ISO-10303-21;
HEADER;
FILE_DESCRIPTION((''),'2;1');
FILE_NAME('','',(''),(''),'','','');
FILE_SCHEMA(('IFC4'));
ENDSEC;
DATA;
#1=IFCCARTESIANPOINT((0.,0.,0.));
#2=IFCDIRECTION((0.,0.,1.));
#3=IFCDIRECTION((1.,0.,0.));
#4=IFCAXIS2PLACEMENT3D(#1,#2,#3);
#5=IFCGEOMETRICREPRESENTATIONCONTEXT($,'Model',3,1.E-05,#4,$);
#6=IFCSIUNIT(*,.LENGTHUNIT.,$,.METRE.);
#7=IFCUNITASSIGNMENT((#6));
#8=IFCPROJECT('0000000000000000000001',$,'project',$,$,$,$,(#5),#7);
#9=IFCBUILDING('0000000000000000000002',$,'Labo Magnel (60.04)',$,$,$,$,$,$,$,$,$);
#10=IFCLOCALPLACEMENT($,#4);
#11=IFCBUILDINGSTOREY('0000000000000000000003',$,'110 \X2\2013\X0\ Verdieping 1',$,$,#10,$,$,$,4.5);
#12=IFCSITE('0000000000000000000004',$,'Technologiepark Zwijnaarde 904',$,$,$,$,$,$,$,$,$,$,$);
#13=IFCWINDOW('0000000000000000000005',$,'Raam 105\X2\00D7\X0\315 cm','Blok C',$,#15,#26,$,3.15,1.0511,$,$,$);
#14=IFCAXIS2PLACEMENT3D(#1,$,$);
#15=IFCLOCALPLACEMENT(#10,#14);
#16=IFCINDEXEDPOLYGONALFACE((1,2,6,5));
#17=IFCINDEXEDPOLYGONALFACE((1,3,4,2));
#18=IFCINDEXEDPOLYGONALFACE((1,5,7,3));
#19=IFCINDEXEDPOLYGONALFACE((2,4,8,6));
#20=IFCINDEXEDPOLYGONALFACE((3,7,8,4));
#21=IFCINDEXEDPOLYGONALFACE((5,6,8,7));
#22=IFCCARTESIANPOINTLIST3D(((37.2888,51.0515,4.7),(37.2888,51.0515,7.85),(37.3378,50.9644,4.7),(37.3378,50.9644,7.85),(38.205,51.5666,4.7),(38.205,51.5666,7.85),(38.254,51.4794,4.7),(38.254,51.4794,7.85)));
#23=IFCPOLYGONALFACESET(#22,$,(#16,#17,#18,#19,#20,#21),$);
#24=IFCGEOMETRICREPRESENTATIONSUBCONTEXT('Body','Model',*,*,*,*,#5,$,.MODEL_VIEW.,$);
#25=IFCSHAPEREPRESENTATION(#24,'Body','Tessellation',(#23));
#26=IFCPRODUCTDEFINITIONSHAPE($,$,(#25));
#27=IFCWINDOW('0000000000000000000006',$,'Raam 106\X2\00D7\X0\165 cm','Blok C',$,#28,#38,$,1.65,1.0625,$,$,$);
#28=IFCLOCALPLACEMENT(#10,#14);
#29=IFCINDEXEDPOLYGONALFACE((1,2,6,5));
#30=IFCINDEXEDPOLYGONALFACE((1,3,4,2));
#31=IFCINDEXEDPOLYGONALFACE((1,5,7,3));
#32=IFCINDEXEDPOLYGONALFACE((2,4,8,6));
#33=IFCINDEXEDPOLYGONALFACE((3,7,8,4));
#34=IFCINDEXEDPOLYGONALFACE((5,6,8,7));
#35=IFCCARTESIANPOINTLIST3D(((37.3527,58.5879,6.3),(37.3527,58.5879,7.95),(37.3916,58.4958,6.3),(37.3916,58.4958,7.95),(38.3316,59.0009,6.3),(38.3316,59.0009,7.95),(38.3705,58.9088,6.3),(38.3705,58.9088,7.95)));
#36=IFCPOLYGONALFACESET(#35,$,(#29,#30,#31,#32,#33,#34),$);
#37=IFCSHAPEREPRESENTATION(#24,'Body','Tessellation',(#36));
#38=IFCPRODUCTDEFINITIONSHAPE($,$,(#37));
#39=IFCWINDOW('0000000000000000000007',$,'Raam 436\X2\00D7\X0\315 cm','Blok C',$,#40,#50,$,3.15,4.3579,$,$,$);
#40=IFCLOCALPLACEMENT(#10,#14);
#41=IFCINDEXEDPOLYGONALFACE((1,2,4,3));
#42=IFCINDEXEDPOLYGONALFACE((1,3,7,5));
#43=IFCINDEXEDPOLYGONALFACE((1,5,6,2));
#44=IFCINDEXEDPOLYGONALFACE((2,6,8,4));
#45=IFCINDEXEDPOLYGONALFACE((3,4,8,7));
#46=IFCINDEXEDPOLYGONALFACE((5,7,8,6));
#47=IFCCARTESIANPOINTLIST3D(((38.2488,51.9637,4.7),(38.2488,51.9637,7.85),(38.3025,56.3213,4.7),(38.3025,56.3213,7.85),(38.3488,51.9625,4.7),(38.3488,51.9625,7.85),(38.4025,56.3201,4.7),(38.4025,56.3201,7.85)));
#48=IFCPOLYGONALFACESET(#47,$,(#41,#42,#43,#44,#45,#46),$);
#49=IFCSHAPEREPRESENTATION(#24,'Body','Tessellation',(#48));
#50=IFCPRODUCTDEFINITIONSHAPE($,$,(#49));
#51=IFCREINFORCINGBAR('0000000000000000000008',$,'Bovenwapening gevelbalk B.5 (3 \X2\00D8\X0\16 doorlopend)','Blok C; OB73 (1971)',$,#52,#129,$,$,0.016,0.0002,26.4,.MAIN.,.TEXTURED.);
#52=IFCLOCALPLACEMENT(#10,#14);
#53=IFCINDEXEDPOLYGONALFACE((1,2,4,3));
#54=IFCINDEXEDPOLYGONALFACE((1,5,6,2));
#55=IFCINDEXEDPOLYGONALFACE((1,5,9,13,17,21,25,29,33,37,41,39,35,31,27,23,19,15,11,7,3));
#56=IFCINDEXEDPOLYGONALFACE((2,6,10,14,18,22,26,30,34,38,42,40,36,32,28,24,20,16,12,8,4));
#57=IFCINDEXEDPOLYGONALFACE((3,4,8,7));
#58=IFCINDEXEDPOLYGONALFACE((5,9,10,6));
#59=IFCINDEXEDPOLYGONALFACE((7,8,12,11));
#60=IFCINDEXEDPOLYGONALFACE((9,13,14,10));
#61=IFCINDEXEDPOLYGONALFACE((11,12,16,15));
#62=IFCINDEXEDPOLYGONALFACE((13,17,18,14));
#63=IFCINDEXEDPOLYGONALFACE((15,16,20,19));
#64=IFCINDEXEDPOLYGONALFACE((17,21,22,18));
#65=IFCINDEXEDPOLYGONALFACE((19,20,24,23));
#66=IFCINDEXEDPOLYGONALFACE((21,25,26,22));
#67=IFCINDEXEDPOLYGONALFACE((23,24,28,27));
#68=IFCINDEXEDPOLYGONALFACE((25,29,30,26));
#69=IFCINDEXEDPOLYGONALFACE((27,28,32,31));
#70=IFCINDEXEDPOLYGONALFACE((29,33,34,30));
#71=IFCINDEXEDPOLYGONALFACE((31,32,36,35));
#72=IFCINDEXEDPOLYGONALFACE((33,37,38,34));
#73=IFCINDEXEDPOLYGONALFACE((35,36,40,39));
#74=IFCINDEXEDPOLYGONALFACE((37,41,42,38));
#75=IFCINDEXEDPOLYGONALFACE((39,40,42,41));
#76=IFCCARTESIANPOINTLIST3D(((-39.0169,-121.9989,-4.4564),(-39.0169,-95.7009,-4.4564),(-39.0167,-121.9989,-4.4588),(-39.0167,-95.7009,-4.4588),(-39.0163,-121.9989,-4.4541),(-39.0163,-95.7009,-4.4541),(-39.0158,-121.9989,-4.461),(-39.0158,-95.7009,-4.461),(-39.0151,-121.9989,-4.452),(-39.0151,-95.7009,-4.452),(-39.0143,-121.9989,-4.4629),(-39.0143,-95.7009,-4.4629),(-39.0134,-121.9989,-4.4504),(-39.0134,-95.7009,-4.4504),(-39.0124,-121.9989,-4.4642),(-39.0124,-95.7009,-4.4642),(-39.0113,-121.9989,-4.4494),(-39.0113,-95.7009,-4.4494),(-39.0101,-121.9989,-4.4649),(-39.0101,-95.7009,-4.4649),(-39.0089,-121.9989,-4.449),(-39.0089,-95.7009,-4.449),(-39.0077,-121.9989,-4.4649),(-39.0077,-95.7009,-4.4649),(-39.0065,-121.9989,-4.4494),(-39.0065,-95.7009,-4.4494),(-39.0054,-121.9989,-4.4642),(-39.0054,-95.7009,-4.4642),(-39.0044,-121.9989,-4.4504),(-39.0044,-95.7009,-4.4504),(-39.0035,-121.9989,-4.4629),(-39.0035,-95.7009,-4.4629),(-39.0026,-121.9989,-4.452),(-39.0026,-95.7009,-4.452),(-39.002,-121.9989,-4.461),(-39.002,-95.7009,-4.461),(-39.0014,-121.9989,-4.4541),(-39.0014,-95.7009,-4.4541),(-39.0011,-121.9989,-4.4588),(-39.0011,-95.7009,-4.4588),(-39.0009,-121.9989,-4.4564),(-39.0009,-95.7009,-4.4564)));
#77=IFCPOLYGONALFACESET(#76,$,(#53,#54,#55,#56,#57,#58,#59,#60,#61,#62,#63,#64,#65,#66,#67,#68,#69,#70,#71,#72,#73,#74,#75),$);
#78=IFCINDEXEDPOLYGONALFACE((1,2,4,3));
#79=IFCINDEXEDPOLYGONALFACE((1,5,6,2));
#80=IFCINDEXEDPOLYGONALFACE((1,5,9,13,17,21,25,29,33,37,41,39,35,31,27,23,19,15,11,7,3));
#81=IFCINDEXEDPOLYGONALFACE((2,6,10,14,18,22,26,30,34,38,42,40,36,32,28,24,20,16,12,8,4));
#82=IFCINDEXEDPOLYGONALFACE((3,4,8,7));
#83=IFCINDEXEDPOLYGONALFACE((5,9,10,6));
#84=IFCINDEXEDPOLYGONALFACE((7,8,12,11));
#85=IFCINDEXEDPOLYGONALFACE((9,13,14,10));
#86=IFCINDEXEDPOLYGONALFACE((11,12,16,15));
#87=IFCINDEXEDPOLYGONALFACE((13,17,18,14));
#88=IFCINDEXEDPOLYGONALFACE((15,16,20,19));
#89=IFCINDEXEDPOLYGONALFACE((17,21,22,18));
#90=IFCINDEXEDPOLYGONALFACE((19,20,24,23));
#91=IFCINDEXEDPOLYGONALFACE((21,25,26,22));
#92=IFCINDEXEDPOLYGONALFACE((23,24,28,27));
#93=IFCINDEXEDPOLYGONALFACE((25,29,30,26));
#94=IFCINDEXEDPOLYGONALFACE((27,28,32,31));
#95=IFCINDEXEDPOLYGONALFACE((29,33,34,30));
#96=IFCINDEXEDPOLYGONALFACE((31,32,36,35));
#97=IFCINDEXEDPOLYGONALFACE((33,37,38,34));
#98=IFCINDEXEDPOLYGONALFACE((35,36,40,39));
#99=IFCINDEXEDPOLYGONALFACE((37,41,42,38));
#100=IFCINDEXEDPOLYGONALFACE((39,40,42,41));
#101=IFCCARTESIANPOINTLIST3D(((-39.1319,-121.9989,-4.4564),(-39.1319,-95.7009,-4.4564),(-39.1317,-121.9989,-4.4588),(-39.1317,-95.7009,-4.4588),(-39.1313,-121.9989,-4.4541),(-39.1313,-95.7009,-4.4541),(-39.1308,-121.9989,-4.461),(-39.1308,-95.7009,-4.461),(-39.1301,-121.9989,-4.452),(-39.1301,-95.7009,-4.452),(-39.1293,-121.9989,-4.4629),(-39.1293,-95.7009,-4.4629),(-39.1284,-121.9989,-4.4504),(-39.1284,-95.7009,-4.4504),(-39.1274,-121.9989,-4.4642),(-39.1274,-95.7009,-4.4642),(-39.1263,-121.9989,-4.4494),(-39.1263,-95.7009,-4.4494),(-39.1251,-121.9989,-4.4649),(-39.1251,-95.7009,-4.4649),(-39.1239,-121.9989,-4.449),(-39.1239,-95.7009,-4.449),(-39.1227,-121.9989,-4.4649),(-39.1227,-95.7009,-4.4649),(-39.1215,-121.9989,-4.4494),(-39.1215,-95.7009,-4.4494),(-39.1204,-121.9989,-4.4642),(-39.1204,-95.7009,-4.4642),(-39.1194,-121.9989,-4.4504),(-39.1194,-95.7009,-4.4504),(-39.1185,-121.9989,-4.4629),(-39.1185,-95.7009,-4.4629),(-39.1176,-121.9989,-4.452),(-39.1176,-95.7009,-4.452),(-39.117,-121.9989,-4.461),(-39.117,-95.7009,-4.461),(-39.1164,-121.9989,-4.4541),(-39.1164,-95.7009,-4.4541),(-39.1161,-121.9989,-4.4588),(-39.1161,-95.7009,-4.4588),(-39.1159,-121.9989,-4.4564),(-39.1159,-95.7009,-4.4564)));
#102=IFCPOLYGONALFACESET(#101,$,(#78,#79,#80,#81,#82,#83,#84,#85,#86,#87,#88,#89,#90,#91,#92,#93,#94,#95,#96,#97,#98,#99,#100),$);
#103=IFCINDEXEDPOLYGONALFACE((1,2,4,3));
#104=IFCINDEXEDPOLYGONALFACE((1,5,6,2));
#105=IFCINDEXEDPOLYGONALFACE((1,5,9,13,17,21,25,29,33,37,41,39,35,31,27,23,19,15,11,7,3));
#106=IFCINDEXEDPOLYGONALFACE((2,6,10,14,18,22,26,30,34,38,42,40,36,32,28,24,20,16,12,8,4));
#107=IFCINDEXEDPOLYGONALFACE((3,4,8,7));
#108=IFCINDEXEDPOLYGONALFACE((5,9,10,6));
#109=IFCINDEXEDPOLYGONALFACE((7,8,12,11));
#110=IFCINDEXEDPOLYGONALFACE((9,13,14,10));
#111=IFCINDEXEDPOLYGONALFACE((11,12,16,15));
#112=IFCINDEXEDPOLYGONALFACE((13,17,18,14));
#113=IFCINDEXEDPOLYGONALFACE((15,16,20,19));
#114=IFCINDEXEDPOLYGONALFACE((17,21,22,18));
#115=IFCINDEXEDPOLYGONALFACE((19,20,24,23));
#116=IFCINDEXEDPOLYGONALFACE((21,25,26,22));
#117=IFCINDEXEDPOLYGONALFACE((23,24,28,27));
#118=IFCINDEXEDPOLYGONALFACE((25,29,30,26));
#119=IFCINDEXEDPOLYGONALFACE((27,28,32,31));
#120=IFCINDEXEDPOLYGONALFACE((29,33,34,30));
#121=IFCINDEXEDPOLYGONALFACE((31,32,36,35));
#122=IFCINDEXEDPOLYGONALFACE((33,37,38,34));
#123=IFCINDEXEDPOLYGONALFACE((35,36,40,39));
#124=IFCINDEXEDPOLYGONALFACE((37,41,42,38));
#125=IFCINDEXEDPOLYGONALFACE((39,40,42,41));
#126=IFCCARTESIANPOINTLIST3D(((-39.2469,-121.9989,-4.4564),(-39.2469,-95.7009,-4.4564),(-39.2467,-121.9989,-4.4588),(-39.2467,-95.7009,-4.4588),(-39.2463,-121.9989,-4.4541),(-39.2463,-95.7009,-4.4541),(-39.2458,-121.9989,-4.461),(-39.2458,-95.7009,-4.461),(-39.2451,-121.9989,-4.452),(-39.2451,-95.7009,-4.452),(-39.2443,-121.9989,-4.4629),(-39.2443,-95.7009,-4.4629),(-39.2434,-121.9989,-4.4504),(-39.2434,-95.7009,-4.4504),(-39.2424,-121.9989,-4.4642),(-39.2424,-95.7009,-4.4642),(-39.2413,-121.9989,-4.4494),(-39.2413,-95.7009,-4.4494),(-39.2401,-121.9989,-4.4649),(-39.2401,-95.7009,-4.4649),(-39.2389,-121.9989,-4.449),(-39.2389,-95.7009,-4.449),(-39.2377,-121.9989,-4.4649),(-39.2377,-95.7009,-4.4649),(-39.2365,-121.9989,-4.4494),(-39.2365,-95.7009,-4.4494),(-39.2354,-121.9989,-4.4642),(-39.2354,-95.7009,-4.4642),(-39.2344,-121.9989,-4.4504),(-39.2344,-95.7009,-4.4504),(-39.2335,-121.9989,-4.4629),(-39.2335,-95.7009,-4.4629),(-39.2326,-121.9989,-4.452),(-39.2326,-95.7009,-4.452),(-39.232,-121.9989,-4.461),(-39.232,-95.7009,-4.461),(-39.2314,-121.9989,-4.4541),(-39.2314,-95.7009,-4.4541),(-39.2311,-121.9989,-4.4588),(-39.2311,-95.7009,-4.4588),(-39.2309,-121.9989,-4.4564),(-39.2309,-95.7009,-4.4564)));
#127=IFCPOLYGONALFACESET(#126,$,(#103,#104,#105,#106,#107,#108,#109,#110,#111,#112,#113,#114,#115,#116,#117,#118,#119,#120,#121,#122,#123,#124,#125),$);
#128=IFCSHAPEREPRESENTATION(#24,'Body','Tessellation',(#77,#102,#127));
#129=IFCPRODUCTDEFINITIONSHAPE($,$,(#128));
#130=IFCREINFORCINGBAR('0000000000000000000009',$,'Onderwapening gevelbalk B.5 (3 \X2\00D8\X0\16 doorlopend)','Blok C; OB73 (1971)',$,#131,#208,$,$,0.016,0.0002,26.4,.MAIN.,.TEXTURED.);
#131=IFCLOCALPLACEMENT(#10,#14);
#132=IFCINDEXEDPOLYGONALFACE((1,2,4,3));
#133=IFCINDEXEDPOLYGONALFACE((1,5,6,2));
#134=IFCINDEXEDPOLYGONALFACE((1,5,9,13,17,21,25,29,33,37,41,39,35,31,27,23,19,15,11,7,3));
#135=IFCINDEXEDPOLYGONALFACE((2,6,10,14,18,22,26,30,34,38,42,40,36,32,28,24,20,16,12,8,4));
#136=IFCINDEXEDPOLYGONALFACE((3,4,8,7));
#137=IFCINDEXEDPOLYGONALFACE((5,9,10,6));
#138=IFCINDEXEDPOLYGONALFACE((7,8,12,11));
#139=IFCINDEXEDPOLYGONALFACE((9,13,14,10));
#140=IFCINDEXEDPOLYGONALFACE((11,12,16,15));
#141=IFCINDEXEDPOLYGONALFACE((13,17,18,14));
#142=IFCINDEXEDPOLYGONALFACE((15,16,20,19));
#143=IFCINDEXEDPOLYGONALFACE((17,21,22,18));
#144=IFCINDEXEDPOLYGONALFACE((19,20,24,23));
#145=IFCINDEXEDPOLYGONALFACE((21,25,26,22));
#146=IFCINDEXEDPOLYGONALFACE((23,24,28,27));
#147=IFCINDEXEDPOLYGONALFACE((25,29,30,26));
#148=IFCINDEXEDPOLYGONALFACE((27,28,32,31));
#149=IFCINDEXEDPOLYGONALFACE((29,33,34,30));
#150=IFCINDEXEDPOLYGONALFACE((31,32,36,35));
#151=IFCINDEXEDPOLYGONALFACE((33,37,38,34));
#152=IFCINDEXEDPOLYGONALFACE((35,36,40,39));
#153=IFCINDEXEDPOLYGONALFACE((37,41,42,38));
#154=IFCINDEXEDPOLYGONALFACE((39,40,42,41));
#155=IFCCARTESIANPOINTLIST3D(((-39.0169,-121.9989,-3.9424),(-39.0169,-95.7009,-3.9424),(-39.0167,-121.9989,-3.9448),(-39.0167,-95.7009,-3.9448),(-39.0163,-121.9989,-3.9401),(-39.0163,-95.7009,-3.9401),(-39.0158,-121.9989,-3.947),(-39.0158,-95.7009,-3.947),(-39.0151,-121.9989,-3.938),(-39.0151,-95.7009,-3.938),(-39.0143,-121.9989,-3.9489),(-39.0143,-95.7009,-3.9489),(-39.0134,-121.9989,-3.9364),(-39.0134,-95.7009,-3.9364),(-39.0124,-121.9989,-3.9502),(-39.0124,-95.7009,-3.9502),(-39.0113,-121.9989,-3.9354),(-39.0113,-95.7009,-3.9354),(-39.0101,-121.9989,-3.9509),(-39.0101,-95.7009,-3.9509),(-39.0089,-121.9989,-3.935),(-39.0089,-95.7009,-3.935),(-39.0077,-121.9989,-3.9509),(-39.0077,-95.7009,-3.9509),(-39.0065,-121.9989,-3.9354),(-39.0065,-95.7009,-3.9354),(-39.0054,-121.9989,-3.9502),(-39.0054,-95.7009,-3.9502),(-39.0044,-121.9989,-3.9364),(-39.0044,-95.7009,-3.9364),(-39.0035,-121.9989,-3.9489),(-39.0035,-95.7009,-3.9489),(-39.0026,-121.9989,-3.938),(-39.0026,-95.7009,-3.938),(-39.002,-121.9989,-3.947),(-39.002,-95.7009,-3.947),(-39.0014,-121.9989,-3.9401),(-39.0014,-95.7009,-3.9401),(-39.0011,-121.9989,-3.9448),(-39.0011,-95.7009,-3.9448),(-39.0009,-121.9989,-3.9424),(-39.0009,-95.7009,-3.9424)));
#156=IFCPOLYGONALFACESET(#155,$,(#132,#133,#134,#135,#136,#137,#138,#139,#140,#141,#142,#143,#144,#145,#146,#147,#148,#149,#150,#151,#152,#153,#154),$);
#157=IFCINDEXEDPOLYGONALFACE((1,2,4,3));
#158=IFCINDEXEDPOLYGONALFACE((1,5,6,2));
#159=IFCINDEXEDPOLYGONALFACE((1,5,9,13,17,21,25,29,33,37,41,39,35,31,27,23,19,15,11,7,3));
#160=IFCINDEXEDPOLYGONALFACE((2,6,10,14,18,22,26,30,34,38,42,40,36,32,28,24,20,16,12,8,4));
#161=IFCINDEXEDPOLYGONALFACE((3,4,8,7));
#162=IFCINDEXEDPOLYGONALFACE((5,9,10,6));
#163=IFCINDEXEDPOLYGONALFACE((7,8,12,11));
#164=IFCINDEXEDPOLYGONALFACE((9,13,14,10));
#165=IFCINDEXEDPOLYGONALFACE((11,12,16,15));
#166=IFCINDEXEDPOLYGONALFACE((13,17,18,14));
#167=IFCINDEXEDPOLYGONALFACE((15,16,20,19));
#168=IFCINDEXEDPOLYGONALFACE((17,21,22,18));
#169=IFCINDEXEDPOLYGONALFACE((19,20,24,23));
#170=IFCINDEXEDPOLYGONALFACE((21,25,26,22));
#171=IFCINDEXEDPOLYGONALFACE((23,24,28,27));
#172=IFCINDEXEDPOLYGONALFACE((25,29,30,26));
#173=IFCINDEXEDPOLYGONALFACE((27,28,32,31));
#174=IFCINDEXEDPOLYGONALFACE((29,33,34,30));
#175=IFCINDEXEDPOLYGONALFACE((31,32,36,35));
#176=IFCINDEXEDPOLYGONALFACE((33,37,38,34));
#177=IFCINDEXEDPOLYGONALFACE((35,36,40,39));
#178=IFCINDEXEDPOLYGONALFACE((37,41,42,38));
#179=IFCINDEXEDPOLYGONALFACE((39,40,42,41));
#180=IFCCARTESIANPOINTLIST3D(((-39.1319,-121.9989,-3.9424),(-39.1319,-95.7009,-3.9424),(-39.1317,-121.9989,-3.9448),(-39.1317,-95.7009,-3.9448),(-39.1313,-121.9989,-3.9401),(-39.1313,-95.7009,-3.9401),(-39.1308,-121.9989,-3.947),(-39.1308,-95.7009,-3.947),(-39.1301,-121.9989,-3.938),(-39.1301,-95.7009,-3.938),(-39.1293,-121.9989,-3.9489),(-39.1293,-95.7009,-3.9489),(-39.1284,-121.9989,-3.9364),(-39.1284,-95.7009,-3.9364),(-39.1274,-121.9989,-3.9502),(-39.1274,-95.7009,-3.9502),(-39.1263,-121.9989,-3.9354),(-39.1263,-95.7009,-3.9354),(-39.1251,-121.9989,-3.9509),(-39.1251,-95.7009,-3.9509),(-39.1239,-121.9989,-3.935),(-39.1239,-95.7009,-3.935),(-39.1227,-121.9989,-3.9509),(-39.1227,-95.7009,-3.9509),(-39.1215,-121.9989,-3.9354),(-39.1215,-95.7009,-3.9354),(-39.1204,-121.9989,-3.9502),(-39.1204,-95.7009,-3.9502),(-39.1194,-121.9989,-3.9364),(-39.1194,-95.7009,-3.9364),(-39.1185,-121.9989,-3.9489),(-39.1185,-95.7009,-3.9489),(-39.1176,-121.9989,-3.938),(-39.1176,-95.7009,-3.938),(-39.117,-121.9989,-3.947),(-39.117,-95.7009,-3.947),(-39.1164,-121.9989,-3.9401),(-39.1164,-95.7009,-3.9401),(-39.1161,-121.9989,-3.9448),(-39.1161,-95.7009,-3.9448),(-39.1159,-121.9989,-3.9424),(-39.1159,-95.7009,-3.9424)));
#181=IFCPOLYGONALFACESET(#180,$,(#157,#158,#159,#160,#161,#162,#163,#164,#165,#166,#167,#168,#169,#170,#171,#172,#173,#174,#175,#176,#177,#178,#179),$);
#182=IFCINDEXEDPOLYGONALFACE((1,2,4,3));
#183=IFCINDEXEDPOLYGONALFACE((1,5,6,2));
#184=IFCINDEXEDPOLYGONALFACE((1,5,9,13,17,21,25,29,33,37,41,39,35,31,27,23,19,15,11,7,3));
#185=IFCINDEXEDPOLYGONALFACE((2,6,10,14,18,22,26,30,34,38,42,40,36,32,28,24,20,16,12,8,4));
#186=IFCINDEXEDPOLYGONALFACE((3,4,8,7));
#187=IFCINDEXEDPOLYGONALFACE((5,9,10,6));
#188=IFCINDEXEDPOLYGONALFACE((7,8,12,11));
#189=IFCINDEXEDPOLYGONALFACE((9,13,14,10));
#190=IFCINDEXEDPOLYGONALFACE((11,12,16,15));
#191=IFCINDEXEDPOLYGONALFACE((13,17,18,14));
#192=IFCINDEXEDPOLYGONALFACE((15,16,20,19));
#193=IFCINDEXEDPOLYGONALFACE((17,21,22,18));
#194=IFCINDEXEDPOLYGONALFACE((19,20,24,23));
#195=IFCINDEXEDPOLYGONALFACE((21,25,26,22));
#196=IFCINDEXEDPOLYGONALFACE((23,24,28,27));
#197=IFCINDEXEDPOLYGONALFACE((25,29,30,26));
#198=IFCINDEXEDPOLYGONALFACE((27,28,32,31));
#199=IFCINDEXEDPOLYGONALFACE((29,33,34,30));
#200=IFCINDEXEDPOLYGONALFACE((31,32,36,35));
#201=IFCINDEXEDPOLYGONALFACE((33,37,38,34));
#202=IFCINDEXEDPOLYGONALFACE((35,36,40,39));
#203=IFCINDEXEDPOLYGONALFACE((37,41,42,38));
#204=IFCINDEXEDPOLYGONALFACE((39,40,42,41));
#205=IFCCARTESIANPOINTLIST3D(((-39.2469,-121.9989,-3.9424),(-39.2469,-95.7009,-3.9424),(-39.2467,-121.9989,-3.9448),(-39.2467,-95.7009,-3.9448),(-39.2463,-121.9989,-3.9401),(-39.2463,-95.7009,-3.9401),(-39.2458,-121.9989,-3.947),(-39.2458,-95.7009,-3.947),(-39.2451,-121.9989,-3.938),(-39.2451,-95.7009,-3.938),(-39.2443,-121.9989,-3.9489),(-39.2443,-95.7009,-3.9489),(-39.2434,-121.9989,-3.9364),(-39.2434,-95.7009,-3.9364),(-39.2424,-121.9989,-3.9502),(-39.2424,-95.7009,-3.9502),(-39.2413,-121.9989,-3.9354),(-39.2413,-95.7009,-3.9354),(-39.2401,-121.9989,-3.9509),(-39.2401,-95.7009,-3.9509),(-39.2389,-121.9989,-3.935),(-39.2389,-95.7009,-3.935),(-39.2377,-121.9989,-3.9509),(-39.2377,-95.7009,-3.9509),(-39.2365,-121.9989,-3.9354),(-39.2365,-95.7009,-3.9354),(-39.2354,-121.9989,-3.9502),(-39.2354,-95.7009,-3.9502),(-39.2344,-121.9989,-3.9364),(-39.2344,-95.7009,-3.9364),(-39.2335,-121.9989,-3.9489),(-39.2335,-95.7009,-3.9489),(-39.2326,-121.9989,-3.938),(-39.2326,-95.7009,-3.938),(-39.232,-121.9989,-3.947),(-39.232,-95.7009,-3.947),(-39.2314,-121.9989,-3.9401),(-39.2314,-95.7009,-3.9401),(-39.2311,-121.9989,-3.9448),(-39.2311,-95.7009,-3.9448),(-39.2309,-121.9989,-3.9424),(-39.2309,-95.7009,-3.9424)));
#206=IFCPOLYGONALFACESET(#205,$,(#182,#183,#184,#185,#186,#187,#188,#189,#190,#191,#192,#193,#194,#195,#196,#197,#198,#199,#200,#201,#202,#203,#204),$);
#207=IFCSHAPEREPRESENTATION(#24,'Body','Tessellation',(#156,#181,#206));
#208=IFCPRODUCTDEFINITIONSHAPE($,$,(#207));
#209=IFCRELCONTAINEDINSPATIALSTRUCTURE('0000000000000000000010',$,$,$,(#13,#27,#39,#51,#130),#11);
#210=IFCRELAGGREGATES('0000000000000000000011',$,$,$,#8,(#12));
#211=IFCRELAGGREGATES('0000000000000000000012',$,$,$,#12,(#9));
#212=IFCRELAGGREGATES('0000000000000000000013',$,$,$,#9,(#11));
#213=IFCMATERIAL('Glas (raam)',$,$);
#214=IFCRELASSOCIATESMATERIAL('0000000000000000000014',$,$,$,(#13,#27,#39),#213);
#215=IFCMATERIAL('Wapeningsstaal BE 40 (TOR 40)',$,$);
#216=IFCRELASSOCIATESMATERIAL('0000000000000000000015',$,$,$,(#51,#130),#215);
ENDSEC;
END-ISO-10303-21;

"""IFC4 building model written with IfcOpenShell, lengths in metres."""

from ifc_helpers import new_model, entity, si_unit, frame, origin, origin_with_axes, place, context, subcontext, project, spatial, polyline, outline, extrude, material, element, save


model = new_model("IFC4")

# Units and contexts
model_context = context("Model", 3, precision=1e-05, world=origin_with_axes())
body_context = subcontext(model_context, "Body", "Model", "MODEL_VIEW")
ifc_project = project(units=[si_unit("LENGTHUNIT", "METRE")], contexts=[model_context])

# Site, building, storey
site = spatial("IfcSite", under=ifc_project, Name="Technologiepark Zwijnaarde 904")
building = spatial("IfcBuilding", under=site, Name="Labo Magnel (60.04)")
storey_placement = place(None, origin_with_axes())
storey = spatial("IfcBuildingStorey", under=building, at=storey_placement, Name="110 – Verdieping 1", Elevation=4.5)

# Windows
ifc_material_1 = material(Name="Glas (raam)")
window_1_placement = place(storey_placement, frame((37.3133, 51.0079, 4.7), z_axis=(0.0, 0.0, 1.0), x_axis=(0.871724, 0.489998, 0.0)))
element("IfcWindow", 1, at=window_1_placement, inside=storey, material=ifc_material_1, Name="Raam 105×315 cm", Description="Blok C", OverallHeight=3.15, OverallWidth=1.0511, context=body_context, shape_type="SweptSolid", body=[
    extrude(outline(polyline([(0.0, -0.05), (1.0511, -0.05), (1.0511, 0.05), (0.0, 0.05), (0.0, -0.05)])), origin(), (0.0, 0.0, 1.0), 3.15),
])
window_2_placement = place(storey_placement, frame((37.3722, 58.5418, 6.3), z_axis=(0.0, 0.0, 1.0), x_axis=(0.92134, 0.388757, 0.0)))
element("IfcWindow", 2, at=window_2_placement, inside=storey, material=ifc_material_1, Name="Raam 106×165 cm", Description="Blok C", OverallHeight=1.65, OverallWidth=1.0625, context=body_context, shape_type="SweptSolid", body=[
    extrude(outline(polyline([(0.0, -0.05), (1.0625, -0.05), (1.0625, 0.05), (0.0, 0.05), (0.0, -0.05)])), origin(), (0.0, 0.0, 1.0), 1.65),
])
window_3_placement = place(storey_placement, frame((38.3525, 56.3207, 4.7), z_axis=(0.0, 0.0, 1.0), x_axis=(-0.012338, -0.999924, 0.0)))
element("IfcWindow", 3, at=window_3_placement, inside=storey, material=ifc_material_1, Name="Raam 436×315 cm", Description="Blok C", OverallHeight=3.15, OverallWidth=4.3579, context=body_context, shape_type="SweptSolid", body=[
    extrude(outline(polyline([(0.0, -0.05), (4.3579, -0.05), (4.3579, 0.05), (0.0, 0.05), (0.0, -0.05)])), origin(), (0.0, 0.0, 1.0), 3.15),
])

# Reinforcing bars
ifc_material_2 = material(Name="Wapeningsstaal BE 40 (TOR 40)")
reinforcing_bar_1_placement = place(storey_placement, origin_with_axes())
element("IfcReinforcingBar", 4, at=reinforcing_bar_1_placement, inside=storey, material=ifc_material_2, Name="Bovenwapening gevelbalk B.5 (3 Ø16 doorlopend)", Description="Blok C; OB73 (1971)", BarLength=26.4, BarSurface="TEXTURED", CrossSectionArea=0.0002, NominalDiameter=0.016, PredefinedType="MAIN", context=body_context, shape_type="AdvancedSweptSolid", body=[
    entity("IfcSweptDiskSolid", entity("IfcPolyline", [entity("IfcCartesianPoint", [39.0089, 95.7009, 4.457]), entity("IfcCartesianPoint", [39.0089, 121.9989, 4.457])]), 0.008),
    entity("IfcSweptDiskSolid", entity("IfcPolyline", [entity("IfcCartesianPoint", [39.1239, 95.7009, 4.457]), entity("IfcCartesianPoint", [39.1239, 121.9989, 4.457])]), 0.008),
    entity("IfcSweptDiskSolid", entity("IfcPolyline", [entity("IfcCartesianPoint", [39.2389, 95.7009, 4.457]), entity("IfcCartesianPoint", [39.2389, 121.9989, 4.457])]), 0.008),
])
reinforcing_bar_2_placement = place(storey_placement, origin_with_axes())
element("IfcReinforcingBar", 5, at=reinforcing_bar_2_placement, inside=storey, material=ifc_material_2, Name="Onderwapening gevelbalk B.5 (3 Ø16 doorlopend)", Description="Blok C; OB73 (1971)", BarLength=26.4, BarSurface="TEXTURED", CrossSectionArea=0.0002, NominalDiameter=0.016, PredefinedType="MAIN", context=body_context, shape_type="AdvancedSweptSolid", body=[
    entity("IfcSweptDiskSolid", entity("IfcPolyline", [entity("IfcCartesianPoint", [39.0089, 95.7009, 3.943]), entity("IfcCartesianPoint", [39.0089, 121.9989, 3.943])]), 0.008),
    entity("IfcSweptDiskSolid", entity("IfcPolyline", [entity("IfcCartesianPoint", [39.1239, 95.7009, 3.943]), entity("IfcCartesianPoint", [39.1239, 121.9989, 3.943])]), 0.008),
    entity("IfcSweptDiskSolid", entity("IfcPolyline", [entity("IfcCartesianPoint", [39.2389, 95.7009, 3.943]), entity("IfcCartesianPoint", [39.2389, 121.9989, 3.943])]), 0.008),
])

save(model, "model.ifc")
